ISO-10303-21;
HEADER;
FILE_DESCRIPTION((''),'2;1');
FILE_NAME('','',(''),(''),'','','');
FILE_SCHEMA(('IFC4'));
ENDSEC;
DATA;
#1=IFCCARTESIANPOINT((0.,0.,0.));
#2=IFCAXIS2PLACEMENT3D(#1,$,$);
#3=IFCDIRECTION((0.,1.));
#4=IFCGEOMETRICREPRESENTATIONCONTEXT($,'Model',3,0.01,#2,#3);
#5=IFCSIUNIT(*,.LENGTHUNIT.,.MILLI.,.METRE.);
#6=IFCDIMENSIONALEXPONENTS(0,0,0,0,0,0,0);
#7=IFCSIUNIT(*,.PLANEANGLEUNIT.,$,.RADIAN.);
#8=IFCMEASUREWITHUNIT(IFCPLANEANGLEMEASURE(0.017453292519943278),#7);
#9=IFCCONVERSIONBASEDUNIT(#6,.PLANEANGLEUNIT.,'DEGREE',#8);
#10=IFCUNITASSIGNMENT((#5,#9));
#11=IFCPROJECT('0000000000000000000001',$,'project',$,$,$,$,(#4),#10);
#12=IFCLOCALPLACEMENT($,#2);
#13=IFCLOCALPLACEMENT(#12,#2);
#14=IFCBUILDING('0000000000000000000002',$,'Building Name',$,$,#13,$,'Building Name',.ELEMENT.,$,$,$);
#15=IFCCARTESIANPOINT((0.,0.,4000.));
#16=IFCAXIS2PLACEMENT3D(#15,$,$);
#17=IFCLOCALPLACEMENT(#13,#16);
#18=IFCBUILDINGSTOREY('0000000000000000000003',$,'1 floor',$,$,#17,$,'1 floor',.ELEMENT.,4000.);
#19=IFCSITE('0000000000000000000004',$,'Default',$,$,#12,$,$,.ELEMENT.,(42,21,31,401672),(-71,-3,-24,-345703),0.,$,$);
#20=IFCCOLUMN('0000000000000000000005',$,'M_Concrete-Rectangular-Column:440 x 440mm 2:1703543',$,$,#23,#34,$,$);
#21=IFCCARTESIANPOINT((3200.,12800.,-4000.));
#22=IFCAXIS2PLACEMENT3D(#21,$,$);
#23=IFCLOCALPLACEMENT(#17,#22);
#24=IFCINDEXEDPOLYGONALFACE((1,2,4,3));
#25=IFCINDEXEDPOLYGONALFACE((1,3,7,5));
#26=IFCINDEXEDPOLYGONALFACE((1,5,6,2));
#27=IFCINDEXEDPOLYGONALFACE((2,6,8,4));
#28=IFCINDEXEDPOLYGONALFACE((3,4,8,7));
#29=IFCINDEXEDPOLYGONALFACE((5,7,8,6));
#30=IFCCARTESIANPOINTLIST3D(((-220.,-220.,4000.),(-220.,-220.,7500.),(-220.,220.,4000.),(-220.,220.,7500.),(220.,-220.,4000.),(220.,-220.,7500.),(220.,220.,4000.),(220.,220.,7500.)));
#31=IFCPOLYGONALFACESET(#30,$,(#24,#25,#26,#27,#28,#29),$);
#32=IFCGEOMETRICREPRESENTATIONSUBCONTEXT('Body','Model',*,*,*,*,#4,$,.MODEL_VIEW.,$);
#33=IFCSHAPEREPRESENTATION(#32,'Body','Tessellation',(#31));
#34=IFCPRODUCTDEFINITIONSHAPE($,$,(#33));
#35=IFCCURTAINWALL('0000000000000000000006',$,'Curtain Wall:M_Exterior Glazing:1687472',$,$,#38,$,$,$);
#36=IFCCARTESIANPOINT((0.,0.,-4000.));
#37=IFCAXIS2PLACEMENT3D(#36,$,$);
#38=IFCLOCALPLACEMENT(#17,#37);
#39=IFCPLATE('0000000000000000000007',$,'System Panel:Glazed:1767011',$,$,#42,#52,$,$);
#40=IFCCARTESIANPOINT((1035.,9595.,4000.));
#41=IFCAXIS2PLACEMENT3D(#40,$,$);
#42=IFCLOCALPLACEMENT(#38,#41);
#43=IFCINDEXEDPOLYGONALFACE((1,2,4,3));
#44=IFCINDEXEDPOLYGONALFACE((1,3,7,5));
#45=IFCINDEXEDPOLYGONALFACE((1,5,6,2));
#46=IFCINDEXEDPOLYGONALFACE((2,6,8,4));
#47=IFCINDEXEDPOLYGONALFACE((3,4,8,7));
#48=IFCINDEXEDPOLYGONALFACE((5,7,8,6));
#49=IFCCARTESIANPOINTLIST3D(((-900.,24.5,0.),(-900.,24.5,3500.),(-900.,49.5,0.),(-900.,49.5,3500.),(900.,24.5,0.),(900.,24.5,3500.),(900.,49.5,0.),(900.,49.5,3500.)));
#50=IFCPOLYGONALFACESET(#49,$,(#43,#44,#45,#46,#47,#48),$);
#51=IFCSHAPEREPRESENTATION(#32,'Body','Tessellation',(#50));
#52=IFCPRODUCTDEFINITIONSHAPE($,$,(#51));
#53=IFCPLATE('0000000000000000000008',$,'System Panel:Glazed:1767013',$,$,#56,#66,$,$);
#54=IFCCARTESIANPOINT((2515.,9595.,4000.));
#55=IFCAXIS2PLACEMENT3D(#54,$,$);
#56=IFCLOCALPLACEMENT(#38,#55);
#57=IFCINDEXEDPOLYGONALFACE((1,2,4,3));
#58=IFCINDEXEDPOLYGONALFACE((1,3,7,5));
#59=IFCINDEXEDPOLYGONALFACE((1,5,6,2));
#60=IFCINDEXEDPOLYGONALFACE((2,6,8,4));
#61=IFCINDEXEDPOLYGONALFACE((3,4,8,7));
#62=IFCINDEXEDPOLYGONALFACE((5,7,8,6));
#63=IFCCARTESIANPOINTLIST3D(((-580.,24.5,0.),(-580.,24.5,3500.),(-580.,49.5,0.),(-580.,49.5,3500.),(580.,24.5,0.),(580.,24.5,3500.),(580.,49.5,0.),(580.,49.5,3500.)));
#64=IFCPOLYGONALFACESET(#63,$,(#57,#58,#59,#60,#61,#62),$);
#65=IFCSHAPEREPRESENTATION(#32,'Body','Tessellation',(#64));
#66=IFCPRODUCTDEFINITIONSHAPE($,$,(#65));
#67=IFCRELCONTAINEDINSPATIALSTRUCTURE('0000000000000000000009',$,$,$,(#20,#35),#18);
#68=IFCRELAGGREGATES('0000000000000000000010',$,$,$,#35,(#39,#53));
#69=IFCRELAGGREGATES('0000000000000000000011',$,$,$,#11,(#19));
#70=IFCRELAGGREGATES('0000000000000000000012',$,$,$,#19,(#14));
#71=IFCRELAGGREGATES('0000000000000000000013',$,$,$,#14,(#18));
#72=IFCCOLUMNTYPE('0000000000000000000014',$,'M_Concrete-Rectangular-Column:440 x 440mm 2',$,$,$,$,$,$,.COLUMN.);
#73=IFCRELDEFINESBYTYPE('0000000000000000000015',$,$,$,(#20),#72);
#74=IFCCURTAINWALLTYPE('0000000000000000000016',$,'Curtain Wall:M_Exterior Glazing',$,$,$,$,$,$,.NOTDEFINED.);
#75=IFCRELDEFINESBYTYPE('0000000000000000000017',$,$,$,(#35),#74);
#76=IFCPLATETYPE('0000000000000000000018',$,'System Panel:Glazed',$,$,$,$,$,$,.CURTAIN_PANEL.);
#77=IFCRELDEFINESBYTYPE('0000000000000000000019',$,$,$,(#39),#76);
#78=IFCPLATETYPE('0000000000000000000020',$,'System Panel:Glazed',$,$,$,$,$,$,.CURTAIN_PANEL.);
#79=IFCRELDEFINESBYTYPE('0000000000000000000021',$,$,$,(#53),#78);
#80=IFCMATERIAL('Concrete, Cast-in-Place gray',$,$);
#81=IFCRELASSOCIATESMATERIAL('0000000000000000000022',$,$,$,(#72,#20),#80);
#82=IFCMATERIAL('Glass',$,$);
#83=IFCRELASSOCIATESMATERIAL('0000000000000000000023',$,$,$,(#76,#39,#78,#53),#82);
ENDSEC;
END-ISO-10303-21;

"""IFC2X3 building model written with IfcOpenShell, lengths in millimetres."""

from ifc_helpers import new_model, entity, si_unit, converted_unit, direction, frame, origin, origin_2d_with_axis, place, context, subcontext, project, spatial, rectangle, extrude, source, transform, mapped, material, type_object, type_shapes, element, aggregate, save


model = new_model("IFC2X3")

# Units and contexts
model_context = context("Model", 3, precision=0.01, world=origin(), true_north=direction((0.0, 1.0)))
body_context = subcontext(model_context, "Body", "Model", "MODEL_VIEW")
ifc_project = project(units=[si_unit("LENGTHUNIT", "METRE", prefix="MILLI"), converted_unit("PLANEANGLEUNIT", "DEGREE", entity("IfcPlaneAngleMeasure", 0.017453292519943278), si_unit("PLANEANGLEUNIT", "RADIAN"), dimensions=[0, 0, 0, 0, 0, 0, 0])], contexts=[model_context])

# Site, building, storey
site_placement = place(None, origin())
site = spatial("IfcSite", under=ifc_project, at=site_placement, Name="Default", CompositionType="ELEMENT", RefLatitude=(42, 21, 31, 401672), RefLongitude=(-71, -3, -24, -345703), RefElevation=0.0)
building_placement = place(site_placement, origin())
building = spatial("IfcBuilding", under=site, at=building_placement, Name="Building Name", LongName="Building Name", CompositionType="ELEMENT")
storey_placement = place(building_placement, frame((0.0, 0.0, 4000.0)))
storey = spatial("IfcBuildingStorey", under=building, at=storey_placement, Name="1 floor", LongName="1 floor", CompositionType="ELEMENT", Elevation=4000.0)

# Column
ifc_material_1 = material(Name="Concrete, Cast-in-Place gray")
column_type = type_object("IfcColumnType", Name="M_Concrete-Rectangular-Column:440 x 440mm 2", PredefinedType="COLUMN", material=ifc_material_1)
shared_shape_1 = source(origin(), body_context, "Body", "SweptSolid", [
    extrude(rectangle(XDim=440.0, YDim=440.0, at=origin_2d_with_axis()), frame((0.0, 0.0, 4000.0), z_axis=(0.0, 0.0, 1.0), x_axis=(-1.0, 0.0, 0.0)), (0.0, 0.0, 1.0), 3500.0),
])
type_shapes(column_type, [shared_shape_1])
column_placement = place(storey_placement, frame((3200.0, 12800.0, -4000.0)))
element("IfcColumn", 1, at=column_placement, inside=storey, type_object=column_type, material=ifc_material_1, Name="M_Concrete-Rectangular-Column:440 x 440mm 2:1703543", context=body_context, shape_type="MappedRepresentation", body=[
    mapped(shared_shape_1, transform((0.0, 0.0, 0.0), scale=1.0)),
])

# Curtain wall, plates
curtain_wall_type = type_object("IfcCurtainWallType", Name="Curtain Wall:M_Exterior Glazing", PredefinedType="NOTDEFINED")
curtain_wall_placement = place(storey_placement, frame((0.0, 0.0, -4000.0)))
curtain_wall = element("IfcCurtainWall", 2, at=curtain_wall_placement, inside=storey, type_object=curtain_wall_type, Name="Curtain Wall:M_Exterior Glazing:1687472")
ifc_material_2 = material(Name="Glass")
plate_type_1 = type_object("IfcPlateType", Name="System Panel:Glazed", PredefinedType="CURTAIN_PANEL", material=ifc_material_2)
shared_shape_2 = source(origin(), body_context, "Body", "SweptSolid", [
    extrude(rectangle(XDim=25.0, YDim=1800.0, at=origin_2d_with_axis()), frame((0.0, 37.0, 0.0), z_axis=(0.0, 0.0, 1.0), x_axis=(0.0, 1.0, 0.0)), (0.0, 0.0, 1.0), 3500.0),
])
type_shapes(plate_type_1, [shared_shape_2])
plate_1_placement = place(curtain_wall_placement, frame((1035.0, 9595.0, 4000.0)))
plate_1 = element("IfcPlate", 3, at=plate_1_placement, type_object=plate_type_1, material=ifc_material_2, Name="System Panel:Glazed:1767011", context=body_context, shape_type="MappedRepresentation", body=[
    mapped(shared_shape_2, transform((0.0, 0.0, 0.0), scale=1.0)),
])
plate_type_2 = type_object("IfcPlateType", Name="System Panel:Glazed", PredefinedType="CURTAIN_PANEL", material=ifc_material_2)
shared_shape_3 = source(origin(), body_context, "Body", "SweptSolid", [
    extrude(rectangle(XDim=25.0, YDim=1160.0, at=origin_2d_with_axis()), frame((0.0, 37.0, 0.0), z_axis=(0.0, 0.0, 1.0), x_axis=(0.0, 1.0, 0.0)), (0.0, 0.0, 1.0), 3500.0),
])
type_shapes(plate_type_2, [shared_shape_3])
plate_2_placement = place(curtain_wall_placement, frame((2515.0, 9595.0, 4000.0)))
plate_2 = element("IfcPlate", 4, at=plate_2_placement, type_object=plate_type_2, material=ifc_material_2, Name="System Panel:Glazed:1767013", context=body_context, shape_type="MappedRepresentation", body=[
    mapped(shared_shape_3, transform((0.0, 0.0, 0.0), scale=1.0)),
])
aggregate(curtain_wall, [plate_1, plate_2])

save(model, "model.ifc")
